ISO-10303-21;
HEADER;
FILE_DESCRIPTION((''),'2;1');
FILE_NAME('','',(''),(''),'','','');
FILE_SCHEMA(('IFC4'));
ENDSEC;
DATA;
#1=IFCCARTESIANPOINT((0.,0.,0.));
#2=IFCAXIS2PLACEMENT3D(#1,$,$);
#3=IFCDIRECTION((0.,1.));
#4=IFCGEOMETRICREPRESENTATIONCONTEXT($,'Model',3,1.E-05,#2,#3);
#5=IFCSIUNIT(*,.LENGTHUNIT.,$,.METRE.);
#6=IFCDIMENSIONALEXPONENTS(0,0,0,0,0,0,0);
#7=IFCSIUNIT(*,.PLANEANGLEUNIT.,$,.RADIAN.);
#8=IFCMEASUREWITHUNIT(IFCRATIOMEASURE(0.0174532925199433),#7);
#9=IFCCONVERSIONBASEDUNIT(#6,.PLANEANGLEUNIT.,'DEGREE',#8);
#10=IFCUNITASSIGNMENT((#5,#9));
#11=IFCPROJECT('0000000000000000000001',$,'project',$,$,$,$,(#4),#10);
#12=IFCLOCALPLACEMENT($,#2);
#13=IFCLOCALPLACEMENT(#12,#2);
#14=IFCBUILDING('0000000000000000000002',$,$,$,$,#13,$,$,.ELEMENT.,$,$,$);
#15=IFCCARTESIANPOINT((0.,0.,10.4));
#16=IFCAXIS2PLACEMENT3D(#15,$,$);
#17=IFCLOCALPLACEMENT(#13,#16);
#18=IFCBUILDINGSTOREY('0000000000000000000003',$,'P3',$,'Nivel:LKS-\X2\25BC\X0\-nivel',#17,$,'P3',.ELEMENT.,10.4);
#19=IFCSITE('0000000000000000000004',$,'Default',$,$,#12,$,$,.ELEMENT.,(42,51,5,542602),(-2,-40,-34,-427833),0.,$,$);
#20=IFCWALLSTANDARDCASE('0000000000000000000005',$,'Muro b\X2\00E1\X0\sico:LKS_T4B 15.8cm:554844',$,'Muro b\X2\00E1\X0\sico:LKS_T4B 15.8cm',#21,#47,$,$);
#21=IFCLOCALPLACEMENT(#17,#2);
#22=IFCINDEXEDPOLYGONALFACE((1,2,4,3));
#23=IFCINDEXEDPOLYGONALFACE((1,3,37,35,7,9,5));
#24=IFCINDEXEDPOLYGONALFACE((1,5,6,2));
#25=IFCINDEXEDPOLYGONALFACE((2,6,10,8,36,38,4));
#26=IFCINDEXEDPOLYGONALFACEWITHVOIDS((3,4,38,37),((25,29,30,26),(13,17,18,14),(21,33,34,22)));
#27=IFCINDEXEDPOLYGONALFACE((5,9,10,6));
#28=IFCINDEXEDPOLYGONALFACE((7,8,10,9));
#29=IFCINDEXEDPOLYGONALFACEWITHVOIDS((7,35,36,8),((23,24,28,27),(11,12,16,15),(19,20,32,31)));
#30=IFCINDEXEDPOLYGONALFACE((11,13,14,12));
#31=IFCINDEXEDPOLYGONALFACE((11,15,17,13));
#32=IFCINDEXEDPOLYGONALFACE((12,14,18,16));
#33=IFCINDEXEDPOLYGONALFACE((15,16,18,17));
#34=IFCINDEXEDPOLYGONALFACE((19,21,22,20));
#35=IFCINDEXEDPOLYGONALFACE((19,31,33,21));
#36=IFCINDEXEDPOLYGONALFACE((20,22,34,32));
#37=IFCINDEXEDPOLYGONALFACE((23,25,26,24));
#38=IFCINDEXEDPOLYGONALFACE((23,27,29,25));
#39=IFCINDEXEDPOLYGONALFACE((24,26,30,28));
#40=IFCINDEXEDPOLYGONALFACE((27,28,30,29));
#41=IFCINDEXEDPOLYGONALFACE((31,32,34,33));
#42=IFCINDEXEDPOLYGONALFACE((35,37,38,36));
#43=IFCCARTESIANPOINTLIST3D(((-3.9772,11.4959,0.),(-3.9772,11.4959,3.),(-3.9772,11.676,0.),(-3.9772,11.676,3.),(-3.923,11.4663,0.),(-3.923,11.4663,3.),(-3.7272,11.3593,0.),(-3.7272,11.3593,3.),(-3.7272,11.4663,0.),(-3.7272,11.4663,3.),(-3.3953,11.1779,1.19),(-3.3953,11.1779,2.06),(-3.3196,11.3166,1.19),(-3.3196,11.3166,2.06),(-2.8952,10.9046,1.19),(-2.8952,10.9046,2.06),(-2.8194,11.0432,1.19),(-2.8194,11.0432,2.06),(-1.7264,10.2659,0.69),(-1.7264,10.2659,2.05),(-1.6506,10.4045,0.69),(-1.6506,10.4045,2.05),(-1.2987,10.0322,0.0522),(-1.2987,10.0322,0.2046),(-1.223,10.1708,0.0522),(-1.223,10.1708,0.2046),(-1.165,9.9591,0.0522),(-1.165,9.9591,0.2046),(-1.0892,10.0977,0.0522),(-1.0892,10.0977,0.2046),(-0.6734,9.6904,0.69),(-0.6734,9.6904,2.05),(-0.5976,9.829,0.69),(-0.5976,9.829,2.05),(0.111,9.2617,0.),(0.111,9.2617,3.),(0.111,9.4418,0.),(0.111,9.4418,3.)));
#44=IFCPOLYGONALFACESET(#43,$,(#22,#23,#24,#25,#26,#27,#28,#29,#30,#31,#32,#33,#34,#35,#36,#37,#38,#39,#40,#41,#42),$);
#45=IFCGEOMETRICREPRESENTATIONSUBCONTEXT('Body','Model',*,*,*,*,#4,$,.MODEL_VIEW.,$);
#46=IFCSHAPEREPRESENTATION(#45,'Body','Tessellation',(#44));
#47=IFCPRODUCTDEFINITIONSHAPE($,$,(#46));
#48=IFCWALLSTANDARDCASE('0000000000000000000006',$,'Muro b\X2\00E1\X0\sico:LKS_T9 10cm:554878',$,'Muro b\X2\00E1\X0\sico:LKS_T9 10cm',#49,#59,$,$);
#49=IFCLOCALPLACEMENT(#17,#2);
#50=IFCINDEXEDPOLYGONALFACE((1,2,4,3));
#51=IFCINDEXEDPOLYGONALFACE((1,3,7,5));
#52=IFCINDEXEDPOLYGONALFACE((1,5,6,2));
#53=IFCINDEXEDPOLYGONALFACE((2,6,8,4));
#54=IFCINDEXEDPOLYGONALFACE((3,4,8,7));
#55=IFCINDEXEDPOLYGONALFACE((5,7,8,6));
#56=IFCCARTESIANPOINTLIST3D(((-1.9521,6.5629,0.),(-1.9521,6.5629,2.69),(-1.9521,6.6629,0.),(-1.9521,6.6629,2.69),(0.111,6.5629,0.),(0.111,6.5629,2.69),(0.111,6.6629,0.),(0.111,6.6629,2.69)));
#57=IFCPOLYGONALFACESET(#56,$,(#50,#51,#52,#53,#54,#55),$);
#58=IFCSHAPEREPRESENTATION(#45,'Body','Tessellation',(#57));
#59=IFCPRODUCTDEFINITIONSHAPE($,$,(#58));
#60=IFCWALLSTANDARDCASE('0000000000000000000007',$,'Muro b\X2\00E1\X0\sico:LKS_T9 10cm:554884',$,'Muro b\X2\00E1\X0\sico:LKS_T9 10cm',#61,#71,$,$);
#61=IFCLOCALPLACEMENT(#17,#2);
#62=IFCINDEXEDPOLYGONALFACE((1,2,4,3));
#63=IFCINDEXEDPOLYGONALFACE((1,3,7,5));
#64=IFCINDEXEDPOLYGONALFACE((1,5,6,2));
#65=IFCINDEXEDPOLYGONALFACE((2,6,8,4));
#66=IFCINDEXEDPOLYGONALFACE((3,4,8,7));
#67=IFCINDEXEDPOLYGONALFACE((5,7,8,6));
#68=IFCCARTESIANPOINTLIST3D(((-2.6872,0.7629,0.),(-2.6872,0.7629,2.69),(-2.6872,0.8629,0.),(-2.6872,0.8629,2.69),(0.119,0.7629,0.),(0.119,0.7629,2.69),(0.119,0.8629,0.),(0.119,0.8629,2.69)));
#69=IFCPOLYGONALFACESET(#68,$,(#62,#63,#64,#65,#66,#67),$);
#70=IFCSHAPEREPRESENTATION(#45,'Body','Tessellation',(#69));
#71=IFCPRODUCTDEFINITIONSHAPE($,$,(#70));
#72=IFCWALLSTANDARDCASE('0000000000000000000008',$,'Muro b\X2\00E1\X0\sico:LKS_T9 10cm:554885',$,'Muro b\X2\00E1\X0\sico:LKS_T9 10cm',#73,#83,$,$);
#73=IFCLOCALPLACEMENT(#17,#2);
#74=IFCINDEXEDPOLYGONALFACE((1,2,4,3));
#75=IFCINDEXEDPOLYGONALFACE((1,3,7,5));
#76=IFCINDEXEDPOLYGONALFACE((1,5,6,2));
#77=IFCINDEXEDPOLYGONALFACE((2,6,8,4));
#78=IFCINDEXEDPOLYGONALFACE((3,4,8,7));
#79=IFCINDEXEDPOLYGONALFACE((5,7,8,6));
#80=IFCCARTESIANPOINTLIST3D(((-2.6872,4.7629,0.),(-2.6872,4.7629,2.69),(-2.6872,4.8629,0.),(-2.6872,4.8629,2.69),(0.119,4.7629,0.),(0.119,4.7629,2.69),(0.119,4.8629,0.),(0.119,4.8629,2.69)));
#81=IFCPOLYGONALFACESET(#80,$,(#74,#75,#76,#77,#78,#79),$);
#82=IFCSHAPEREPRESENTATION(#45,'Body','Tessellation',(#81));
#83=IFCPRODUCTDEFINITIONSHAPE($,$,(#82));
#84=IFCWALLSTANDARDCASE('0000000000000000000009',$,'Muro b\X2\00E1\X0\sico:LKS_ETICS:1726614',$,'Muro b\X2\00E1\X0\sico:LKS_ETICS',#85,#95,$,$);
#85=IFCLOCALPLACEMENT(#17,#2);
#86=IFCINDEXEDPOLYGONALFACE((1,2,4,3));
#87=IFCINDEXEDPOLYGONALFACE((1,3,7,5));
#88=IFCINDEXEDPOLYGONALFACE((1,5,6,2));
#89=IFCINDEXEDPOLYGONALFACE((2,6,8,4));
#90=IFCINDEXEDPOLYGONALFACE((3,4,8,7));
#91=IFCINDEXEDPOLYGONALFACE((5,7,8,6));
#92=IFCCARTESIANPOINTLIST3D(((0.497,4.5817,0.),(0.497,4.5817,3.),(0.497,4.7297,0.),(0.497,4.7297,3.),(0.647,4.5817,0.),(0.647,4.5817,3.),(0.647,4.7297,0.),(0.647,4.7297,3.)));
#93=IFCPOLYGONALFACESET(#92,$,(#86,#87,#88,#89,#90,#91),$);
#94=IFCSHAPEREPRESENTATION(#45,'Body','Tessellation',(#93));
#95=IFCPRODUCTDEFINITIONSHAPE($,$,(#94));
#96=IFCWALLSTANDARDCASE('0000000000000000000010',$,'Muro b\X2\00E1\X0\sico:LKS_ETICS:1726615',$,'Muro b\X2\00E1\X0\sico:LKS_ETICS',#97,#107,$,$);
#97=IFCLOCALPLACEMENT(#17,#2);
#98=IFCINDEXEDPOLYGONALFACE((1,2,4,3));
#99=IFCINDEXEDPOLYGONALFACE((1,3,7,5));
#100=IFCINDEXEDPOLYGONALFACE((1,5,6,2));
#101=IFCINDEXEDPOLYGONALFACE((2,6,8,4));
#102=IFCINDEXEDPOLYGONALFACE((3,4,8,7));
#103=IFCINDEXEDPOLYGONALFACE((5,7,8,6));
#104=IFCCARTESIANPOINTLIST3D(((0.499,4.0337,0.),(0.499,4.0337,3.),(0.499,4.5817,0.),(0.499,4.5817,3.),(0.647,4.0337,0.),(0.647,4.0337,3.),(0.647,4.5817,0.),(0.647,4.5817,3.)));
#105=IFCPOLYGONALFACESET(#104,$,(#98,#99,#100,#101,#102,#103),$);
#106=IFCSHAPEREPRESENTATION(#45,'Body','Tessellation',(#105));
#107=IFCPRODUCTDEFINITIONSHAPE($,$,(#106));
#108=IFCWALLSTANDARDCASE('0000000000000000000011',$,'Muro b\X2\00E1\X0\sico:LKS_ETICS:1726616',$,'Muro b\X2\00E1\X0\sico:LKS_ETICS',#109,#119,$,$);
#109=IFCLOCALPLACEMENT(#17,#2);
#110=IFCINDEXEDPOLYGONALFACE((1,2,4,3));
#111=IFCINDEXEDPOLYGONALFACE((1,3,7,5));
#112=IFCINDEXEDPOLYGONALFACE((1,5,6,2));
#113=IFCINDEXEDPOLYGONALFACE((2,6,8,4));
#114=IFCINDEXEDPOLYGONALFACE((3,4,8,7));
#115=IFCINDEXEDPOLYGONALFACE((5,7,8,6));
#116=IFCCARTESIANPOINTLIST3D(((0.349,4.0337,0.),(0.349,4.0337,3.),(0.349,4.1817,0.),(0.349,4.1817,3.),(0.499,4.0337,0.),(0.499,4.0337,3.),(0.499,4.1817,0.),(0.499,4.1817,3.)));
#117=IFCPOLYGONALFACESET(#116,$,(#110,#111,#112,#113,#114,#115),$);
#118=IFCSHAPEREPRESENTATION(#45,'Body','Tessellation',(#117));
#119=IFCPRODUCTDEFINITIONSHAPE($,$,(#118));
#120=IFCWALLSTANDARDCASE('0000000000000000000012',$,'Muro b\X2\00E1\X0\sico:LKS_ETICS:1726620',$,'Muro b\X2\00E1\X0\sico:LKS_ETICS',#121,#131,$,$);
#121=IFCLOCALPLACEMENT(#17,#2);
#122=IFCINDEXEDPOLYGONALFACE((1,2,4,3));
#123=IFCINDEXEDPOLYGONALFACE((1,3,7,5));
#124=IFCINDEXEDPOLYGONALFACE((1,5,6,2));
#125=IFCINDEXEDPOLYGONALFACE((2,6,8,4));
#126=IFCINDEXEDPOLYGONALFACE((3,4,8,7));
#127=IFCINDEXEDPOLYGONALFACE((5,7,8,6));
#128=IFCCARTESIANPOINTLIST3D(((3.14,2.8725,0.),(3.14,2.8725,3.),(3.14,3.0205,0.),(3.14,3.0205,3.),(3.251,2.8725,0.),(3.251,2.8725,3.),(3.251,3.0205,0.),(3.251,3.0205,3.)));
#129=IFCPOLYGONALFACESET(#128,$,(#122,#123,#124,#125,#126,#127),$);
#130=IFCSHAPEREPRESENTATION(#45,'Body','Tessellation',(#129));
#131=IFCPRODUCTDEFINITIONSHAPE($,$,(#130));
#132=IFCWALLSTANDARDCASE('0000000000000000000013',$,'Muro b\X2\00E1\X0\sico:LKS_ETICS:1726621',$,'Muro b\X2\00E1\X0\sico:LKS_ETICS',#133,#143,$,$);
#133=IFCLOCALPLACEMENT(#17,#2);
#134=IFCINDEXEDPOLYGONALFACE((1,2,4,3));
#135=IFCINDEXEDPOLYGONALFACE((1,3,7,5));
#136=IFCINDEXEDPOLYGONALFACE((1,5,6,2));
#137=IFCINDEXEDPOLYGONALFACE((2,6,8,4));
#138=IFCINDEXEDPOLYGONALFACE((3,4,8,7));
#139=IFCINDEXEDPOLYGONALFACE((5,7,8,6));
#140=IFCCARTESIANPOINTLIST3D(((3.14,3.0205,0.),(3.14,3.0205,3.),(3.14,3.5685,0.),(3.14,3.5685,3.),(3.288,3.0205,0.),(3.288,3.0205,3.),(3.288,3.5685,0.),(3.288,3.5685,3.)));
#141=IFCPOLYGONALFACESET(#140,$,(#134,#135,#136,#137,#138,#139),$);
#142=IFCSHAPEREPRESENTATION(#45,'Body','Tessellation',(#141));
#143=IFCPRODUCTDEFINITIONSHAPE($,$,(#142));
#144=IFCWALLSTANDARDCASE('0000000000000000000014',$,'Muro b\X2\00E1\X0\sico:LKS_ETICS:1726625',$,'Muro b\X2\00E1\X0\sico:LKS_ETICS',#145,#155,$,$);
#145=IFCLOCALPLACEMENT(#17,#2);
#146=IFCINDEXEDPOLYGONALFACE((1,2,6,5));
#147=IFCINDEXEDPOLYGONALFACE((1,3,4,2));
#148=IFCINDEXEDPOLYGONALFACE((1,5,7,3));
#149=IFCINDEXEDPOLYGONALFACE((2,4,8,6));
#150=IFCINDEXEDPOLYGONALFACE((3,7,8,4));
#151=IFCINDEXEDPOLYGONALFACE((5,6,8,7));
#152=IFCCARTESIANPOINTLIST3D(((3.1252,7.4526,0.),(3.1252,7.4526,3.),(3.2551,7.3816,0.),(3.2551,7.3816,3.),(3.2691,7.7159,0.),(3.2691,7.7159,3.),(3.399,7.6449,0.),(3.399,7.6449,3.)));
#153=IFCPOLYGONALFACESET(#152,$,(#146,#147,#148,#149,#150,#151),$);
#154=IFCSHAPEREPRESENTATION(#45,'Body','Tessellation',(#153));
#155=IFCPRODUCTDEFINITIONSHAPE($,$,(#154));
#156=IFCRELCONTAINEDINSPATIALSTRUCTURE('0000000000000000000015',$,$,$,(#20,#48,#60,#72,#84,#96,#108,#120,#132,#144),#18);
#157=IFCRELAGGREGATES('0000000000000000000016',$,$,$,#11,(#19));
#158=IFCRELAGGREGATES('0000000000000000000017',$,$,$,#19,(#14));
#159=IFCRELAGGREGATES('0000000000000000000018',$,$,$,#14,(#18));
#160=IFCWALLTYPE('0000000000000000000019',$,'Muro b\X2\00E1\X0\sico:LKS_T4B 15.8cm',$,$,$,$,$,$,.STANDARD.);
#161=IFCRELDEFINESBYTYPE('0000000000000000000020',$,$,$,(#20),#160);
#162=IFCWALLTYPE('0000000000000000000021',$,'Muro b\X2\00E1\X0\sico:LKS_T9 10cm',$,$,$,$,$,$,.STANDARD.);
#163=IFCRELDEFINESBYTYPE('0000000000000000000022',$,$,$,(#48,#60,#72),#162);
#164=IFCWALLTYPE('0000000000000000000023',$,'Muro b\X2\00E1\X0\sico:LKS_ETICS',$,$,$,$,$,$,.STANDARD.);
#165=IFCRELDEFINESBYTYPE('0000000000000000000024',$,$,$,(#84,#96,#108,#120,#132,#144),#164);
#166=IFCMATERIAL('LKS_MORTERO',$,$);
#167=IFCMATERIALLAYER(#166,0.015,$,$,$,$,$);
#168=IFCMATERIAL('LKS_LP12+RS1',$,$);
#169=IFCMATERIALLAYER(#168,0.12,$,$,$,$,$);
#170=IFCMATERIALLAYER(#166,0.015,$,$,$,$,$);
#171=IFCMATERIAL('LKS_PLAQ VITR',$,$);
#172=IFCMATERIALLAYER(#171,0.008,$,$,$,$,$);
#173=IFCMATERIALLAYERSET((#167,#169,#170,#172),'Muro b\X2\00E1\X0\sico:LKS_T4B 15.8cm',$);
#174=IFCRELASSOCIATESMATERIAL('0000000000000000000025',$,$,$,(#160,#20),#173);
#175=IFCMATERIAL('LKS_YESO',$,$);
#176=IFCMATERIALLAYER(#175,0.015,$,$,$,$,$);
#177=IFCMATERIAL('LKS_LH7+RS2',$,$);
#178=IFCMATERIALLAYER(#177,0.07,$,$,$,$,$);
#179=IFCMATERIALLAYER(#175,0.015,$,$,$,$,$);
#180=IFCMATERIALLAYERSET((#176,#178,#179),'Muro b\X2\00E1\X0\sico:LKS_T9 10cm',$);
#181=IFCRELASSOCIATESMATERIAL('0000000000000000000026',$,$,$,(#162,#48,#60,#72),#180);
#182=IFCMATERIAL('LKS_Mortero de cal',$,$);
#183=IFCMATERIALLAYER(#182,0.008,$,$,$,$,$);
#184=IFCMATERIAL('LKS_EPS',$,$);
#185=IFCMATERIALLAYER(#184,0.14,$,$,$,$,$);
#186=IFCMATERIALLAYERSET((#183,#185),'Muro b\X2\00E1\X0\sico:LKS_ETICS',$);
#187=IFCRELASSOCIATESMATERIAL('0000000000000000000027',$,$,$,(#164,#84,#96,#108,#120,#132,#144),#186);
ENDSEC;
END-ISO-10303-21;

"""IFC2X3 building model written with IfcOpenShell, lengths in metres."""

from ifc_helpers import new_model, entity, si_unit, converted_unit, direction, frame, frame_2d, origin, place, context, subcontext, project, spatial, polyline, rectangle, outline, extrude, clip, bounded_halfspace, material, layer, layer_set, layer_usage, type_object, element, save


model = new_model("IFC2X3")

# Units and contexts
model_context = context("Model", 3, precision=1e-05, world=origin(), true_north=direction((0.0, 1.0)))
body_context = subcontext(model_context, "Body", "Model", "MODEL_VIEW")
ifc_project = project(units=[si_unit("LENGTHUNIT", "METRE"), converted_unit("PLANEANGLEUNIT", "DEGREE", entity("IfcRatioMeasure", 0.0174532925199433), si_unit("PLANEANGLEUNIT", "RADIAN"), dimensions=[0, 0, 0, 0, 0, 0, 0])], contexts=[model_context])

# Site, building, storey
site_placement = place(None, origin())
site = spatial("IfcSite", under=ifc_project, at=site_placement, Name="Default", CompositionType="ELEMENT", RefLatitude=(42, 51, 5, 542602), RefLongitude=(-2, -40, -34, -427833), RefElevation=0.0)
building_placement = place(site_placement, origin())
building = spatial("IfcBuilding", under=site, at=building_placement, CompositionType="ELEMENT")
storey_placement = place(building_placement, frame((0.0, 0.0, 10.4)))
storey = spatial("IfcBuildingStorey", under=building, at=storey_placement, Name="P3", ObjectType="Nivel:LKS-▼-nivel", LongName="P3", CompositionType="ELEMENT", Elevation=10.4)

# Wall, openings
ifc_material_1 = material(Name="LKS_MORTERO")
ifc_layer_1 = layer(ifc_material_1, 0.015)
ifc_material_2 = material(Name="LKS_LP12+RS1")
ifc_layer_2 = layer(ifc_material_2, 0.12)
ifc_layer_3 = layer(ifc_material_1, 0.015)
ifc_material_3 = material(Name="LKS_PLAQ VITR")
ifc_layer_4 = layer(ifc_material_3, 0.008)
ifc_layer_set_1 = layer_set([ifc_layer_1, ifc_layer_2, ifc_layer_3, ifc_layer_4], Name="Muro básico:LKS_T4B 15.8cm")
ifc_layer_usage_1 = layer_usage(ifc_layer_set_1, "AXIS2", "NEGATIVE", 0.079)
wall_type_1 = type_object("IfcWallType", Name="Muro básico:LKS_T4B 15.8cm", PredefinedType="STANDARD", material=ifc_layer_set_1)
wall_1_placement = place(storey_placement, frame((0.1488, 9.3311, 0.0), z_axis=(0.0, 0.0, 1.0), x_axis=(-0.877509, 0.479561, 0.0)))
wall_1 = element("IfcWallStandardCase", 1, at=wall_1_placement, inside=storey, type_object=wall_type_1, material=ifc_layer_usage_1, Name="Muro básico:LKS_T4B 15.8cm:554844", ObjectType="Muro básico:LKS_T4B 15.8cm", context=body_context, shape_type="Clipping", body=[
    clip(clip(extrude(outline(polyline([(4.7451, -0.079), (4.6588, 0.079), (4.5971, 0.079), (4.4252, -0.0149), (4.3739, 0.079), (2.8965, 0.079), (2.7965, 0.079), (0.0, 0.079), (0.0863, -0.079), (4.7451, -0.079)])), origin(), (0.0, 0.0, 1.0), 3.0), bounded_halfspace(frame((4.4252, -0.0149, 3.0), z_axis=(-0.877509, -0.479561, 0.0), x_axis=(0.0, 0.0, -1.0)), True, frame((4.4252, -0.0149, 3.0), z_axis=(-0.877509, -0.479561, 0.0), x_axis=(0.0, 0.0, -1.0)), polyline([(0.0, 0.0), (0.0, -0.107), (3.0, -0.107), (3.0, 0.0), (0.33, 0.0), (0.0, 0.0)]))), bounded_halfspace(frame((4.4252, -0.0149, 0.0), z_axis=(0.479561, -0.877509, 0.0), x_axis=(0.0, 0.0, -1.0)), True, frame((4.4252, -0.0149, 0.0), z_axis=(0.479561, -0.877509, 0.0), x_axis=(0.0, 0.0, -1.0)), polyline([(0.0, 0.0), (0.0, 0.1959), (-3.0, 0.1959), (-3.0, 0.0), (-2.67, 0.0), (0.0, 0.0)]))),
])
opening_1_placement = place(wall_1_placement, origin())
element("IfcOpeningElement", 2, at=opening_1_placement, cuts=wall_1, ObjectType="Opening", context=body_context, shape_type="SweptSolid", body=[
    extrude(rectangle(XDim=0.1524, YDim=0.1524, at=frame_2d((0.0, 0.0), x_axis=(0.0, 1.0))), frame((1.5303, -1.445, 0.1284), z_axis=(0.0, 1.0, 0.0), x_axis=(-1.0, 0.0, 0.0)), (0.0, 0.0, 1.0), 3.048),
])
opening_2_placement = place(wall_1_placement, frame((2.0939, 0.079, 0.69)))
element("IfcOpeningElement", 3, at=opening_2_placement, cuts=wall_1, ObjectType="Opening", context=body_context, shape_type="SweptSolid", body=[
    extrude(rectangle(XDim=1.36, YDim=1.2, at=frame_2d((0.68, 0.6), x_axis=(1.0, 0.0))), frame((0.0, 0.0, 0.0), z_axis=(0.0, -1.0, 0.0), x_axis=(0.0, 0.0, 1.0)), (0.0, 0.0, 1.0), 0.158),
])
opening_3_placement = place(wall_1_placement, frame((3.9957, 0.079, 1.19)))
element("IfcOpeningElement", 4, at=opening_3_placement, cuts=wall_1, ObjectType="Opening", context=body_context, shape_type="SweptSolid", body=[
    extrude(rectangle(XDim=0.87, YDim=0.57, at=frame_2d((0.435, 0.285), x_axis=(1.0, 0.0))), frame((0.0, 0.0, 0.0), z_axis=(0.0, -1.0, 0.0), x_axis=(0.0, 0.0, 1.0)), (0.0, 0.0, 1.0), 0.158),
])

# Walls
ifc_material_4 = material(Name="LKS_YESO")
ifc_layer_5 = layer(ifc_material_4, 0.015)
ifc_material_5 = material(Name="LKS_LH7+RS2")
ifc_layer_6 = layer(ifc_material_5, 0.07)
ifc_layer_7 = layer(ifc_material_4, 0.015)
ifc_layer_set_2 = layer_set([ifc_layer_5, ifc_layer_6, ifc_layer_7], Name="Muro básico:LKS_T9 10cm")
ifc_layer_usage_2 = layer_usage(ifc_layer_set_2, "AXIS2", "NEGATIVE", 0.05)
wall_type_2 = type_object("IfcWallType", Name="Muro básico:LKS_T9 10cm", PredefinedType="STANDARD", material=ifc_layer_set_2)
wall_2_placement = place(storey_placement, frame((0.111, 6.6129, 0.0), z_axis=(0.0, 0.0, 1.0), x_axis=(-1.0, 0.0, 0.0)))
element("IfcWallStandardCase", 5, at=wall_2_placement, inside=storey, type_object=wall_type_2, material=ifc_layer_usage_2, Name="Muro básico:LKS_T9 10cm:554878", ObjectType="Muro básico:LKS_T9 10cm", context=body_context, shape_type="SweptSolid", body=[
    extrude(rectangle(XDim=2.0631, YDim=0.1, at=frame_2d((1.0315, 0.0), x_axis=(-1.0, 0.0))), origin(), (0.0, 0.0, 1.0), 2.69),
])
ifc_layer_usage_3 = layer_usage(ifc_layer_set_2, "AXIS2", "NEGATIVE", 0.05)
wall_3_placement = place(storey_placement, frame((0.119, 0.8129, 0.0), z_axis=(0.0, 0.0, 1.0), x_axis=(-1.0, 0.0, 0.0)))
element("IfcWallStandardCase", 6, at=wall_3_placement, inside=storey, type_object=wall_type_2, material=ifc_layer_usage_3, Name="Muro básico:LKS_T9 10cm:554884", ObjectType="Muro básico:LKS_T9 10cm", context=body_context, shape_type="SweptSolid", body=[
    extrude(rectangle(XDim=2.8061, YDim=0.1, at=frame_2d((1.4031, 0.0), x_axis=(-1.0, 0.0))), origin(), (0.0, 0.0, 1.0), 2.69),
])
ifc_layer_usage_4 = layer_usage(ifc_layer_set_2, "AXIS2", "NEGATIVE", 0.05)
wall_4_placement = place(storey_placement, frame((0.119, 4.8129, 0.0), z_axis=(0.0, 0.0, 1.0), x_axis=(-1.0, 0.0, 0.0)))
element("IfcWallStandardCase", 7, at=wall_4_placement, inside=storey, type_object=wall_type_2, material=ifc_layer_usage_4, Name="Muro básico:LKS_T9 10cm:554885", ObjectType="Muro básico:LKS_T9 10cm", context=body_context, shape_type="SweptSolid", body=[
    extrude(rectangle(XDim=2.8061, YDim=0.1, at=frame_2d((1.4031, 0.0), x_axis=(-1.0, 0.0))), origin(), (0.0, 0.0, 1.0), 2.69),
])

# Walls
ifc_material_6 = material(Name="LKS_Mortero de cal")
ifc_layer_8 = layer(ifc_material_6, 0.008)
ifc_material_7 = material(Name="LKS_EPS")
ifc_layer_9 = layer(ifc_material_7, 0.14)
ifc_layer_set_3 = layer_set([ifc_layer_8, ifc_layer_9], Name="Muro básico:LKS_ETICS")
ifc_layer_usage_5 = layer_usage(ifc_layer_set_3, "AXIS2", "NEGATIVE", 0.074)
wall_type_3 = type_object("IfcWallType", Name="Muro básico:LKS_ETICS", PredefinedType="STANDARD", material=ifc_layer_set_3)
wall_5_placement = place(storey_placement, frame((0.497, 4.6557, 0.0)))
element("IfcWallStandardCase", 8, at=wall_5_placement, inside=storey, type_object=wall_type_3, material=ifc_layer_usage_5, Name="Muro básico:LKS_ETICS:1726614", ObjectType="Muro básico:LKS_ETICS", context=body_context, shape_type="SweptSolid", body=[
    extrude(rectangle(XDim=0.15, YDim=0.148, at=frame_2d((0.075, 0.0), x_axis=(-1.0, 0.0))), origin(), (0.0, 0.0, 1.0), 3.0),
])
ifc_layer_usage_6 = layer_usage(ifc_layer_set_3, "AXIS2", "NEGATIVE", 0.074)
wall_6_placement = place(storey_placement, frame((0.573, 4.5817, 0.0), z_axis=(0.0, 0.0, 1.0), x_axis=(0.0, -1.0, 0.0)))
element("IfcWallStandardCase", 9, at=wall_6_placement, inside=storey, type_object=wall_type_3, material=ifc_layer_usage_6, Name="Muro básico:LKS_ETICS:1726615", ObjectType="Muro básico:LKS_ETICS", context=body_context, shape_type="SweptSolid", body=[
    extrude(rectangle(XDim=0.548, YDim=0.148, at=frame_2d((0.274, 0.0), x_axis=(-1.0, 0.0))), origin(), (0.0, 0.0, 1.0), 3.0),
])
ifc_layer_usage_7 = layer_usage(ifc_layer_set_3, "AXIS2", "NEGATIVE", 0.074)
wall_7_placement = place(storey_placement, frame((0.499, 4.1077, 0.0), z_axis=(0.0, 0.0, 1.0), x_axis=(-1.0, 0.0, 0.0)))
element("IfcWallStandardCase", 10, at=wall_7_placement, inside=storey, type_object=wall_type_3, material=ifc_layer_usage_7, Name="Muro básico:LKS_ETICS:1726616", ObjectType="Muro básico:LKS_ETICS", context=body_context, shape_type="SweptSolid", body=[
    extrude(rectangle(XDim=0.15, YDim=0.148, at=frame_2d((0.075, 0.0), x_axis=(-1.0, 0.0))), origin(), (0.0, 0.0, 1.0), 3.0),
])
ifc_layer_usage_8 = layer_usage(ifc_layer_set_3, "AXIS2", "NEGATIVE", 0.074)
wall_8_placement = place(storey_placement, frame((3.251, 2.9465, 0.0), z_axis=(0.0, 0.0, 1.0), x_axis=(-1.0, 0.0, 0.0)))
element("IfcWallStandardCase", 11, at=wall_8_placement, inside=storey, type_object=wall_type_3, material=ifc_layer_usage_8, Name="Muro básico:LKS_ETICS:1726620", ObjectType="Muro básico:LKS_ETICS", context=body_context, shape_type="SweptSolid", body=[
    extrude(rectangle(XDim=0.111, YDim=0.148, at=frame_2d((0.0555, 0.0), x_axis=(-1.0, 0.0))), origin(), (0.0, 0.0, 1.0), 3.0),
])
ifc_layer_usage_9 = layer_usage(ifc_layer_set_3, "AXIS2", "NEGATIVE", 0.074)
wall_9_placement = place(storey_placement, frame((3.214, 3.0205, 0.0), z_axis=(0.0, 0.0, 1.0), x_axis=(0.0, 1.0, 0.0)))
element("IfcWallStandardCase", 12, at=wall_9_placement, inside=storey, type_object=wall_type_3, material=ifc_layer_usage_9, Name="Muro básico:LKS_ETICS:1726621", ObjectType="Muro básico:LKS_ETICS", context=body_context, shape_type="SweptSolid", body=[
    extrude(rectangle(XDim=0.548, YDim=0.148, at=frame_2d((0.274, 0.0), x_axis=(-1.0, 0.0))), origin(), (0.0, 0.0, 1.0), 3.0),
])
ifc_layer_usage_10 = layer_usage(ifc_layer_set_3, "AXIS2", "NEGATIVE", 0.074)
wall_10_placement = place(storey_placement, frame((3.1902, 7.4171, 0.0), z_axis=(0.0, 0.0, 1.0), x_axis=(0.479561, 0.877509, 0.0)))
element("IfcWallStandardCase", 13, at=wall_10_placement, inside=storey, type_object=wall_type_3, material=ifc_layer_usage_10, Name="Muro básico:LKS_ETICS:1726625", ObjectType="Muro básico:LKS_ETICS", context=body_context, shape_type="SweptSolid", body=[
    extrude(rectangle(XDim=0.3, YDim=0.148, at=frame_2d((0.15, 0.0), x_axis=(-1.0, 0.0))), origin(), (0.0, 0.0, 1.0), 3.0),
])

save(model, "model.ifc")
